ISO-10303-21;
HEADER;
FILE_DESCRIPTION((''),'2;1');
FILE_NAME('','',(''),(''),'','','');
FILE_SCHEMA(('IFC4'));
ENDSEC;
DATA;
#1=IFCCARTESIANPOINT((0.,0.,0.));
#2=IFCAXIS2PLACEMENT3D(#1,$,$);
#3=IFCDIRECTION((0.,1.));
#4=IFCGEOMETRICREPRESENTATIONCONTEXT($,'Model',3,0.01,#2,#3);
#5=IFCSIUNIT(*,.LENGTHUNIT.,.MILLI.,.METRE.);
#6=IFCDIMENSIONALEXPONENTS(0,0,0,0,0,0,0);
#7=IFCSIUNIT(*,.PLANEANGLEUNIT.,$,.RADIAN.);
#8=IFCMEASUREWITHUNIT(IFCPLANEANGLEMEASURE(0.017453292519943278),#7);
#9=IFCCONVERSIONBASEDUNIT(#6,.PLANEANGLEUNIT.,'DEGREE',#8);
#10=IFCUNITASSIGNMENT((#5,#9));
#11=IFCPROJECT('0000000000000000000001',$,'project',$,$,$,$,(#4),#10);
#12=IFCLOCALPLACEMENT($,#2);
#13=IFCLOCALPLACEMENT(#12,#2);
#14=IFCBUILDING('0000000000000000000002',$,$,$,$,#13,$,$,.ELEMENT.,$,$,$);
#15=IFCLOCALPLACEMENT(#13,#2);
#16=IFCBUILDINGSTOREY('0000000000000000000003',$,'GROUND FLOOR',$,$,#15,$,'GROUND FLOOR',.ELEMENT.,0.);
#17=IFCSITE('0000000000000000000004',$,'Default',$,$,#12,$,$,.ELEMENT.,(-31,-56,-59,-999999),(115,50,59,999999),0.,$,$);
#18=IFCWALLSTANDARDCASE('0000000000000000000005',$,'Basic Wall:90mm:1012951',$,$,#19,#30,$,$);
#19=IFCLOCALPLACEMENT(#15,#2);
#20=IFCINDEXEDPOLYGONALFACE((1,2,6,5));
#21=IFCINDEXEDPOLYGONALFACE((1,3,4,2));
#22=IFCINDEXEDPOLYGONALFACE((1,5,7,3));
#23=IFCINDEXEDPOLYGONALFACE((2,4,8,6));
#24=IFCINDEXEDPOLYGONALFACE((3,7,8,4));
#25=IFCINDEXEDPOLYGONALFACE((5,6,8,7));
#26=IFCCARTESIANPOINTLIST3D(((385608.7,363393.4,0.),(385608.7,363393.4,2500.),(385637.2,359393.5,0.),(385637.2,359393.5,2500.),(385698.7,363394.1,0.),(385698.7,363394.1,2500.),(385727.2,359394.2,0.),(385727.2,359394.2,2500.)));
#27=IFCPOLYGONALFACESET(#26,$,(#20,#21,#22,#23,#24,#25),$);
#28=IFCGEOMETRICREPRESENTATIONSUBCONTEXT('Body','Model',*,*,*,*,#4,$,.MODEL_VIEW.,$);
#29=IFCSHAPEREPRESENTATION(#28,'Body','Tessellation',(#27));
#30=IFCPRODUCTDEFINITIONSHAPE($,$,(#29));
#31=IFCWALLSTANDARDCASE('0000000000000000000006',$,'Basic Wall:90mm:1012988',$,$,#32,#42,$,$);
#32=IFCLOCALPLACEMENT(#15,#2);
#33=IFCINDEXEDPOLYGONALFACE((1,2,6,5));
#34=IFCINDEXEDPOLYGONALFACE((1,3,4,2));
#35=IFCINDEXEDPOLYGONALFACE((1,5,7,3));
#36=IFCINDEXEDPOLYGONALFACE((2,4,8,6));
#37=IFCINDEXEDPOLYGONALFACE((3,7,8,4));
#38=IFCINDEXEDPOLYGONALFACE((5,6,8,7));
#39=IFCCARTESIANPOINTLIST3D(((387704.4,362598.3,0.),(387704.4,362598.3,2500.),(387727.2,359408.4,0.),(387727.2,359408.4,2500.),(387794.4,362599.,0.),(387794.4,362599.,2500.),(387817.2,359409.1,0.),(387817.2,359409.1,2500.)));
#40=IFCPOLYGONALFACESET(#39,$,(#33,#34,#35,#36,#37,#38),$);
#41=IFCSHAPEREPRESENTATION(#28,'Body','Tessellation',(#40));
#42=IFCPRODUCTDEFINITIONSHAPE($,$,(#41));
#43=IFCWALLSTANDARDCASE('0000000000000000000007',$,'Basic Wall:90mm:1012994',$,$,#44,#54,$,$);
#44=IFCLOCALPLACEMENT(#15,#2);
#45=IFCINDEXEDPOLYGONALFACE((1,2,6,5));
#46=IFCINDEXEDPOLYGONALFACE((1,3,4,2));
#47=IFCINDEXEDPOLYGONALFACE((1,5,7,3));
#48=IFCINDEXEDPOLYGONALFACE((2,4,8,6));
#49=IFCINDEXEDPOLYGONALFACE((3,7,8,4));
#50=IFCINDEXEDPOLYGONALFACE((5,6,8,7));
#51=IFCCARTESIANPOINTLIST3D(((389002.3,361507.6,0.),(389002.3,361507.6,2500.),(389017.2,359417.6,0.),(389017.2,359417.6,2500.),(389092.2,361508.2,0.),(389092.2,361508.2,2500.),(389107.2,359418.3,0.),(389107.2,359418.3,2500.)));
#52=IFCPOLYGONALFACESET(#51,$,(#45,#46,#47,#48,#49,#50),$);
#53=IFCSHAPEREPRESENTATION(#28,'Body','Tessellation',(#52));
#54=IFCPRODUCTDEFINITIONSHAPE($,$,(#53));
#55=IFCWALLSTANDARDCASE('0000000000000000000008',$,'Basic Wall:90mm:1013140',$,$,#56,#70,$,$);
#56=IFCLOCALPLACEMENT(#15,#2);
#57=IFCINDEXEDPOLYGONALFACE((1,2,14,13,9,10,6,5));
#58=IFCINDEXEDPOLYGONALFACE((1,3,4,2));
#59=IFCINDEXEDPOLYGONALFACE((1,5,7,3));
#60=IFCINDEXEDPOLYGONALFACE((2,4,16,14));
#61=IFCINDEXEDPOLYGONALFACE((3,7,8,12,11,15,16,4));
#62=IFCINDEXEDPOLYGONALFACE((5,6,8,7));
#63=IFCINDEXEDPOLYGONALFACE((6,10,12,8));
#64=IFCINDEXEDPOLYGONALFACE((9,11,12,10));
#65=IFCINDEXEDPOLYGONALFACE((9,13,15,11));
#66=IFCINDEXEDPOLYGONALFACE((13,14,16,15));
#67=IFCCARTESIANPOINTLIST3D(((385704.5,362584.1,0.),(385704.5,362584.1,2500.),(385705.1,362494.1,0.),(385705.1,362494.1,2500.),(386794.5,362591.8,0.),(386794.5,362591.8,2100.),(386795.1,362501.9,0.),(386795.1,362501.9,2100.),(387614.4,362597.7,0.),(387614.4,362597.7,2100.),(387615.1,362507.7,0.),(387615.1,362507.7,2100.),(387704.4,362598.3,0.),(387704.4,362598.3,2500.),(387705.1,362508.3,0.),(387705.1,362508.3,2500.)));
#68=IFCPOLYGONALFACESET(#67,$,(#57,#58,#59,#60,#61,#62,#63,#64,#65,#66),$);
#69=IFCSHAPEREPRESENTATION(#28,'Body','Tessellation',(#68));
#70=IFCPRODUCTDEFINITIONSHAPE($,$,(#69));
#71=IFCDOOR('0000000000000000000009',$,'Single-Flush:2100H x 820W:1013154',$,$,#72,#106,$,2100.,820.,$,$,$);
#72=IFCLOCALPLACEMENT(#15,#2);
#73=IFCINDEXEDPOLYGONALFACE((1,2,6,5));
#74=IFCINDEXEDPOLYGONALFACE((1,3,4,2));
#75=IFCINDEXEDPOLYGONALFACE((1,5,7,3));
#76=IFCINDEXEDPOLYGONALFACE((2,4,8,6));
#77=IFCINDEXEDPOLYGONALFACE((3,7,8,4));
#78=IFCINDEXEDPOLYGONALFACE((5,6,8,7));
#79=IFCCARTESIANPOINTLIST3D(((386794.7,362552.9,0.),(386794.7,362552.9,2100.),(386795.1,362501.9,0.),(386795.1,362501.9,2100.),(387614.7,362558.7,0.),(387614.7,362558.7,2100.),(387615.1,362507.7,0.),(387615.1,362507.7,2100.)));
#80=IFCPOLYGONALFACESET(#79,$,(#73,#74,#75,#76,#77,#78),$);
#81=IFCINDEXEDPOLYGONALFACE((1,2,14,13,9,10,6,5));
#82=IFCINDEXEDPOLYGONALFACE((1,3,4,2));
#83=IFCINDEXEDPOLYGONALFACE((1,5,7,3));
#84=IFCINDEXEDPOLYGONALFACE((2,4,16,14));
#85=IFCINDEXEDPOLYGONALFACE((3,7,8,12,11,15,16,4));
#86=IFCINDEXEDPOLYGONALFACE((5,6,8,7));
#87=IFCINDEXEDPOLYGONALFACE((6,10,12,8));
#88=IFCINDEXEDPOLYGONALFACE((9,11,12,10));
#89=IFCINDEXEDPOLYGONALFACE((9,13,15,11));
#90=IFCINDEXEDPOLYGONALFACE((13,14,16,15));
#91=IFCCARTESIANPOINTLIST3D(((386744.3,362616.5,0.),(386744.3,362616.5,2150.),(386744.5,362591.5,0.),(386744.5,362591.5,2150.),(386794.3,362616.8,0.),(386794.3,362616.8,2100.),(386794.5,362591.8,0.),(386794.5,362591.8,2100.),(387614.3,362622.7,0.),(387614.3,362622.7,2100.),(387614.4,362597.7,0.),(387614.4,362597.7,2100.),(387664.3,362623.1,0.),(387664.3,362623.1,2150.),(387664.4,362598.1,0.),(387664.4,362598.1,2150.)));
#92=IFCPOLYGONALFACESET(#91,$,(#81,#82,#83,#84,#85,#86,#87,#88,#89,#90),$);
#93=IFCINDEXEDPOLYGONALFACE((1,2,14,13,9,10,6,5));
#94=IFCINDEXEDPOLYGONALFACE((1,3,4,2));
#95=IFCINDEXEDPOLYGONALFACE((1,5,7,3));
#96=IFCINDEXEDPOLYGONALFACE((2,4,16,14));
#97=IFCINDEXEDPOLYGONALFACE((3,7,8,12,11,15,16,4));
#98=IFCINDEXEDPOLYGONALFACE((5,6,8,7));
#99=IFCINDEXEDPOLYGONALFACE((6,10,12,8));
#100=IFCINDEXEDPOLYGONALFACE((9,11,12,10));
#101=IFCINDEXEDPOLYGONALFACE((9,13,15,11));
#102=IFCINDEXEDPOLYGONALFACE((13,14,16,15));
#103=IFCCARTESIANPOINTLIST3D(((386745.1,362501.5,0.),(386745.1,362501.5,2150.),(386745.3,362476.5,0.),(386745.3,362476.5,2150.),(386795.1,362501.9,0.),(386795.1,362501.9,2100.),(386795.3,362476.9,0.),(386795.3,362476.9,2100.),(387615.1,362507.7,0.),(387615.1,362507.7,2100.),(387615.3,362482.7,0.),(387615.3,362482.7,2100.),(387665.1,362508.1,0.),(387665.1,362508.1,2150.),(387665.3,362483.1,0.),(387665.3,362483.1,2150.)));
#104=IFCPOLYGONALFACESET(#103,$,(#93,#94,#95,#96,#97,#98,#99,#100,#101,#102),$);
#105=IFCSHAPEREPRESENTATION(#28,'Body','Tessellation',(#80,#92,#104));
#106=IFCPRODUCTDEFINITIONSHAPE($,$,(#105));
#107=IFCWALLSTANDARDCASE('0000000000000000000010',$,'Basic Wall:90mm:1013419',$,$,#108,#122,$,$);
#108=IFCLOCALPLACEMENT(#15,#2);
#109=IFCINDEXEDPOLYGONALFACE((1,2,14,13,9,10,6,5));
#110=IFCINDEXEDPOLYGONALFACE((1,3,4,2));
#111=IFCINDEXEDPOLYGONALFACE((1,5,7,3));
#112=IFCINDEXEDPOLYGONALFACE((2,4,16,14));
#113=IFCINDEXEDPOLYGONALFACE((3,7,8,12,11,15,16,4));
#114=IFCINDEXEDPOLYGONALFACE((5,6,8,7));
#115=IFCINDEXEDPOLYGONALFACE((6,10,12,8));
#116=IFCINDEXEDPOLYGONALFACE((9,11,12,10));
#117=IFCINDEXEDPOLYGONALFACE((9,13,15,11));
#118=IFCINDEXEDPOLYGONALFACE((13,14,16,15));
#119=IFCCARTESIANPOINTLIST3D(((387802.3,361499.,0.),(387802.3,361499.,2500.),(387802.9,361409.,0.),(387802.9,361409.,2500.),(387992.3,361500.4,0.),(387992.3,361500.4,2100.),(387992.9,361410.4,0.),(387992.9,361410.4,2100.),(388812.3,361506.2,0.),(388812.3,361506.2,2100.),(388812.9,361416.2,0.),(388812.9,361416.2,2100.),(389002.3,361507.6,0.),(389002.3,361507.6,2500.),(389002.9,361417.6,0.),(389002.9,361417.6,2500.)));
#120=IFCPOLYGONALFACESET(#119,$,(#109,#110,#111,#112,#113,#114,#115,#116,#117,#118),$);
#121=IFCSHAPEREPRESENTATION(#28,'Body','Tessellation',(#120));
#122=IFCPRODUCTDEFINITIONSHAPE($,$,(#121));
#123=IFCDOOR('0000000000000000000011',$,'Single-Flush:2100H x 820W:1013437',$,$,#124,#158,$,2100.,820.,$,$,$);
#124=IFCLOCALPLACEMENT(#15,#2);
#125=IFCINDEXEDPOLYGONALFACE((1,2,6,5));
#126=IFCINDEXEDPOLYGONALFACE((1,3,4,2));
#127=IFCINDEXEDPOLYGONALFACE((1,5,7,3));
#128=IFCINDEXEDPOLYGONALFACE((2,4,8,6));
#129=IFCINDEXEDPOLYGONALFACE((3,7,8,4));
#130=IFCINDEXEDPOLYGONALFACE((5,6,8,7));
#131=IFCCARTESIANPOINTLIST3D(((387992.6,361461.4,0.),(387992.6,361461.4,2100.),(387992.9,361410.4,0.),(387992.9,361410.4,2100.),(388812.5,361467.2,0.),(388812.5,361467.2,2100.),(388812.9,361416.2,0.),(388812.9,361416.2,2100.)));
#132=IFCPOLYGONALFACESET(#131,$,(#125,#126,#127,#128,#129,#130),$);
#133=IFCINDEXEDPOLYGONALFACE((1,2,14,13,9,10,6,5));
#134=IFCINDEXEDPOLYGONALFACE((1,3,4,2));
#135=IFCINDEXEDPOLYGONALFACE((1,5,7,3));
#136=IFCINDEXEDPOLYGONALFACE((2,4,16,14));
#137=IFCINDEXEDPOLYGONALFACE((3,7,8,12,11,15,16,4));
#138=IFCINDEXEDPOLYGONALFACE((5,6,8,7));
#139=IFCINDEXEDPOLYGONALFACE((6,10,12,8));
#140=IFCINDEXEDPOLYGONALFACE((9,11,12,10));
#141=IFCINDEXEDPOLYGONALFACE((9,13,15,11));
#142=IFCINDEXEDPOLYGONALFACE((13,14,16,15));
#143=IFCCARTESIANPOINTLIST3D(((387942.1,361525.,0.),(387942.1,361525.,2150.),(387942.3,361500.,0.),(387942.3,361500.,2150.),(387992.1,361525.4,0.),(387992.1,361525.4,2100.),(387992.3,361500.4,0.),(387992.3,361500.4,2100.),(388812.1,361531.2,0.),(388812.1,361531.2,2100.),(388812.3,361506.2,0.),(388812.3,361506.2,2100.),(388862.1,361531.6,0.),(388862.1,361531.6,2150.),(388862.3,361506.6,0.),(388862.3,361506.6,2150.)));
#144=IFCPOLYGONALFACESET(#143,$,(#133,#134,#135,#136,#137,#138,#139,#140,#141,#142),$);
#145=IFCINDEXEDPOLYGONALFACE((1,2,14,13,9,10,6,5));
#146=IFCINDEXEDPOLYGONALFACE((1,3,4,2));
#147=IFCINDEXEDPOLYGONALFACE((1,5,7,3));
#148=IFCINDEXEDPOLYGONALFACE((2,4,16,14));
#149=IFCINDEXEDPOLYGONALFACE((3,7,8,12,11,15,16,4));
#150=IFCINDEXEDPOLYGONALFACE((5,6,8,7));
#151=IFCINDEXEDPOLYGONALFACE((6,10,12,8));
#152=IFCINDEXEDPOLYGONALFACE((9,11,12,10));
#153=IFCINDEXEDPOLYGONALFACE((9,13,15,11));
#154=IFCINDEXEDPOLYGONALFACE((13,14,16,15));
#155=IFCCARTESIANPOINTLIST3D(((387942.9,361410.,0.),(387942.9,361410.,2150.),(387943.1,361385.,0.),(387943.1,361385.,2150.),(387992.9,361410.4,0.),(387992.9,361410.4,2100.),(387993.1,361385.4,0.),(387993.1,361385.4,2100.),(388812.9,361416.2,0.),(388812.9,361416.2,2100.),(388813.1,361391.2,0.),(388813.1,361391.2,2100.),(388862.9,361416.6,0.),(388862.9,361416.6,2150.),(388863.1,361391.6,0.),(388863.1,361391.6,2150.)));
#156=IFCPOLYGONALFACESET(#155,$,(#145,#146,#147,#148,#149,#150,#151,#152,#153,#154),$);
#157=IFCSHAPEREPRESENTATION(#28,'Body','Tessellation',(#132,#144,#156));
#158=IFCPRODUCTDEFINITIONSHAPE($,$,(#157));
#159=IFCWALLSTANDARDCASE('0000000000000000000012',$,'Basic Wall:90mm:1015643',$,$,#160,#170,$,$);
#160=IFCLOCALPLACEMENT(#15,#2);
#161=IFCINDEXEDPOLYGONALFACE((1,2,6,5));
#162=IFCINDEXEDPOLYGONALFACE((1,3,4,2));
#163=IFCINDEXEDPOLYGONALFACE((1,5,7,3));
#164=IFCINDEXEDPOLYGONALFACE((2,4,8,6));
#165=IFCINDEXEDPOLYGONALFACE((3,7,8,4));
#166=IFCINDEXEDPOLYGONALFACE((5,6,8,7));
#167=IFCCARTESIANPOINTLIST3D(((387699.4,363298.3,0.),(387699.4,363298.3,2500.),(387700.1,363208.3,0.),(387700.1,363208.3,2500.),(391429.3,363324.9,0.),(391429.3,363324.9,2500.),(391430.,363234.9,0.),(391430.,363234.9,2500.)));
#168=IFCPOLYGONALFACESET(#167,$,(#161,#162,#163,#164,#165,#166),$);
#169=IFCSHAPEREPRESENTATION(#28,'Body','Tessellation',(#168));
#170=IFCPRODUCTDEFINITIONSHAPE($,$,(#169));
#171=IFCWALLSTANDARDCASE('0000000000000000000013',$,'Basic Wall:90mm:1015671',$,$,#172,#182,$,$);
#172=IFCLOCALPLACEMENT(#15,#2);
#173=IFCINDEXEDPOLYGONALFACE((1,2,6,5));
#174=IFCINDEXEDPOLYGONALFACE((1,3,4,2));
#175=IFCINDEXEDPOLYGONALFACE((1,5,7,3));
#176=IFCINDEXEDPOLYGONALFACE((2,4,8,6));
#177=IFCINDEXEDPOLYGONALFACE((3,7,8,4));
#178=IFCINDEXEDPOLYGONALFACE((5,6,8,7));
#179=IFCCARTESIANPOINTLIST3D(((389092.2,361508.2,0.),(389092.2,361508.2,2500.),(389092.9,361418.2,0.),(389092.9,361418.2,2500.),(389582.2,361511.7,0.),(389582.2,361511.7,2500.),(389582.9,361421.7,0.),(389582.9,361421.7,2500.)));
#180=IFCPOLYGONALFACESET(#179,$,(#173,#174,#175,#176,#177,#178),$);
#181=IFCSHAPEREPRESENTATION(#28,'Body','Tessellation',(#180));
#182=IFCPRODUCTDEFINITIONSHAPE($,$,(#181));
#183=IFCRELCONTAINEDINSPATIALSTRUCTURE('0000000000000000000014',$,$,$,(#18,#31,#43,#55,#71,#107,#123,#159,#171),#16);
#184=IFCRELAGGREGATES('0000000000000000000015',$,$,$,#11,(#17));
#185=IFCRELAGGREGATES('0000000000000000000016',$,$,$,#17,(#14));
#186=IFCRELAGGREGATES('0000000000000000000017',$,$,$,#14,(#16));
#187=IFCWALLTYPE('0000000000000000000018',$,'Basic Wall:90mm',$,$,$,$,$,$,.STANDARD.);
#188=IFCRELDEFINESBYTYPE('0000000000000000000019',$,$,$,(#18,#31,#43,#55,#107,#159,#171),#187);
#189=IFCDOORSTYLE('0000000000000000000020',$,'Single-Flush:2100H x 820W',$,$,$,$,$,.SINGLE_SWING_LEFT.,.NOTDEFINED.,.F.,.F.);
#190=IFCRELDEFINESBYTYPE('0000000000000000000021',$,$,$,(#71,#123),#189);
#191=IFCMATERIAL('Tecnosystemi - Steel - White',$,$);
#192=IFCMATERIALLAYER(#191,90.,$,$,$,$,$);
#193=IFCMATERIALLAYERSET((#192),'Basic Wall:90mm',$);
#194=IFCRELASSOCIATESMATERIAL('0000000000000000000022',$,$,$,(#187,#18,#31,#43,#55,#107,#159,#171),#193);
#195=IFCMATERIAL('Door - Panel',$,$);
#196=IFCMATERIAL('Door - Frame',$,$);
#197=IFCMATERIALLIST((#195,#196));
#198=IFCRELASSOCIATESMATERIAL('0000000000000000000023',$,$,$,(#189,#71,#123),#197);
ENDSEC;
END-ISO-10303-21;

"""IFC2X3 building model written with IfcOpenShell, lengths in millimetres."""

from ifc_helpers import new_model, entity, si_unit, converted_unit, direction, frame, frame_2d, origin, origin_2d_with_axis, place, context, subcontext, project, spatial, polyline, rectangle, outline, extrude, source, transform, mapped, material, material_list, layer, layer_set, layer_usage, type_object, type_shapes, element, fill, save


model = new_model("IFC2X3")

# Units and contexts
model_context = context("Model", 3, precision=0.01, world=origin(), true_north=direction((0.0, 1.0)))
body_context = subcontext(model_context, "Body", "Model", "MODEL_VIEW")
ifc_project = project(units=[si_unit("LENGTHUNIT", "METRE", prefix="MILLI"), converted_unit("PLANEANGLEUNIT", "DEGREE", entity("IfcPlaneAngleMeasure", 0.017453292519943278), si_unit("PLANEANGLEUNIT", "RADIAN"), dimensions=[0, 0, 0, 0, 0, 0, 0])], contexts=[model_context])

# Site, building, storey
site_placement = place(None, origin())
site = spatial("IfcSite", under=ifc_project, at=site_placement, Name="Default", CompositionType="ELEMENT", RefLatitude=(-31, -56, -59, -999999), RefLongitude=(115, 50, 59, 999999), RefElevation=0.0)
building_placement = place(site_placement, origin())
building = spatial("IfcBuilding", under=site, at=building_placement, CompositionType="ELEMENT")
storey_placement = place(building_placement, origin())
storey = spatial("IfcBuildingStorey", under=building, at=storey_placement, Name="GROUND FLOOR", LongName="GROUND FLOOR", CompositionType="ELEMENT", Elevation=0.0)

# Walls
ifc_material_1 = material(Name="Tecnosystemi - Steel - White")
ifc_layer_1 = layer(ifc_material_1, 90.0)
ifc_layer_set_1 = layer_set([ifc_layer_1], Name="Basic Wall:90mm")
ifc_layer_usage_1 = layer_usage(ifc_layer_set_1, "AXIS2", "NEGATIVE", 45.0)
wall_type_1 = type_object("IfcWallType", Name="Basic Wall:90mm", PredefinedType="STANDARD", material=ifc_layer_set_1)
wall_1_placement = place(storey_placement, frame((385653.7, 363393.7, 0.0), z_axis=(0.0, 0.0, 1.0), x_axis=(0.007134, -0.999975, 0.0)))
element("IfcWallStandardCase", 1, at=wall_1_placement, inside=storey, type_object=wall_type_1, material=ifc_layer_usage_1, Name="Basic Wall:90mm:1012951", context=body_context, shape_type="SweptSolid", body=[
    extrude(rectangle(XDim=4000.0, YDim=90.0, at=frame_2d((2000.0, 0.0), x_axis=(-1.0, 0.0))), origin(), (0.0, 0.0, 1.0), 2500.0),
])
ifc_layer_usage_2 = layer_usage(ifc_layer_set_1, "AXIS2", "NEGATIVE", 45.0)
wall_2_placement = place(storey_placement, frame((387749.4, 362598.7, 0.0), z_axis=(0.0, 0.0, 1.0), x_axis=(0.007134, -0.999975, 0.0)))
element("IfcWallStandardCase", 2, at=wall_2_placement, inside=storey, type_object=wall_type_1, material=ifc_layer_usage_2, Name="Basic Wall:90mm:1012988", context=body_context, shape_type="SweptSolid", body=[
    extrude(rectangle(XDim=3190.0, YDim=90.0, at=frame_2d((1595.0, 0.0), x_axis=(-1.0, 0.0))), origin(), (0.0, 0.0, 1.0), 2500.0),
])
ifc_layer_usage_3 = layer_usage(ifc_layer_set_1, "AXIS2", "NEGATIVE", 45.0)
wall_3_placement = place(storey_placement, frame((389047.3, 361507.9, 0.0), z_axis=(0.0, 0.0, 1.0), x_axis=(0.007134, -0.999975, 0.0)))
element("IfcWallStandardCase", 3, at=wall_3_placement, inside=storey, type_object=wall_type_1, material=ifc_layer_usage_3, Name="Basic Wall:90mm:1012994", context=body_context, shape_type="SweptSolid", body=[
    extrude(rectangle(XDim=2090.0, YDim=90.0, at=frame_2d((1045.0, 0.0), x_axis=(-1.0, 0.0))), origin(), (0.0, 0.0, 1.0), 2500.0),
])

# Walls, openings, doors
ifc_layer_usage_4 = layer_usage(ifc_layer_set_1, "AXIS2", "NEGATIVE", 45.0)
wall_4_placement = place(storey_placement, frame((385704.8, 362539.1, 0.0), z_axis=(0.0, 0.0, 1.0), x_axis=(0.999975, 0.007134, 0.0)))
wall_4 = element("IfcWallStandardCase", 4, at=wall_4_placement, inside=storey, type_object=wall_type_1, material=ifc_layer_usage_4, Name="Basic Wall:90mm:1013140", context=body_context, shape_type="SweptSolid", body=[
    extrude(rectangle(XDim=2000.0, YDim=90.0, at=frame_2d((1000.0, 0.0), x_axis=(1.0, 0.0))), origin(), (0.0, 0.0, 1.0), 2500.0),
])
opening_1_placement = place(wall_4_placement, frame((1910.0, 45.0, 0.0)))
opening_1 = element("IfcOpeningElement", 5, at=opening_1_placement, cuts=wall_4, ObjectType="Opening", context=body_context, shape_type="SweptSolid", body=[
    extrude(rectangle(XDim=820.0, YDim=2100.0, at=frame_2d((1050.0, 410.0), x_axis=(0.0, -1.0))), frame((0.0, 0.0, 0.0), z_axis=(0.0, -1.0, 0.0), x_axis=(0.0, 0.0, 1.0)), (0.0, 0.0, 1.0), 90.0),
])
ifc_material_2 = material(Name="Door - Panel")
ifc_material_3 = material(Name="Door - Frame")
ifc_material_list_1 = material_list([ifc_material_2, ifc_material_3])
door_style_1 = type_object("IfcDoorStyle", Name="Single-Flush:2100H x 820W", ConstructionType="NOTDEFINED", OperationType="SINGLE_SWING_LEFT", ParameterTakesPrecedence=False, Sizeable=False, material=ifc_material_list_1)
shared_shape_1 = source(origin(), body_context, "Body", "SweptSolid", [
    extrude(rectangle(XDim=820.0, YDim=51.0, at=origin_2d_with_axis()), frame((410.0, 64.5, 0.0)), (0.0, 0.0, 1.0), 2100.0),
    extrude(outline(polyline([(-1087.5, -460.0), (1062.5, -460.0), (1062.5, -410.0), (-1037.5, -410.0), (-1037.5, 410.0), (1062.5, 410.0), (1062.5, 460.0), (-1087.5, 460.0), (-1087.5, -460.0)])), frame((410.0, 0.0, 1062.5), z_axis=(0.0, -1.0, 0.0), x_axis=(0.0, 0.0, -1.0)), (0.0, 0.0, 1.0), 25.0),
    extrude(outline(polyline([(-460.0, -1087.5), (460.0, -1087.5), (460.0, 1062.5), (410.0, 1062.5), (410.0, -1037.5), (-410.0, -1037.5), (-410.0, 1062.5), (-460.0, 1062.5), (-460.0, -1087.5)])), frame((410.0, 115.0, 1062.5), z_axis=(0.0, -1.0, 0.0), x_axis=(-1.0, 0.0, 0.0)), (0.0, 0.0, 1.0), 25.0),
])
type_shapes(door_style_1, [shared_shape_1])
door_1_placement = place(opening_1_placement, frame((0.0, 0.0, 0.0), z_axis=(0.0, 0.0, 1.0), x_axis=(-1.0, 0.0, 0.0)))
door_1 = element("IfcDoor", 6, at=door_1_placement, inside=storey, type_object=door_style_1, material=ifc_material_list_1, Name="Single-Flush:2100H x 820W:1013154", OverallHeight=2100.0, OverallWidth=820.0, context=body_context, shape_type="MappedRepresentation", body=[
    mapped(shared_shape_1, transform((0.0, 0.0, 0.0), scale=1.0)),
])
fill(opening_1, door_1)
ifc_layer_usage_5 = layer_usage(ifc_layer_set_1, "AXIS2", "NEGATIVE", 45.0)
wall_5_placement = place(storey_placement, frame((387802.6, 361454.0, 0.0), z_axis=(0.0, 0.0, 1.0), x_axis=(0.999975, 0.007134, 0.0)))
wall_5 = element("IfcWallStandardCase", 7, at=wall_5_placement, inside=storey, type_object=wall_type_1, material=ifc_layer_usage_5, Name="Basic Wall:90mm:1013419", context=body_context, shape_type="SweptSolid", body=[
    extrude(rectangle(XDim=1200.0, YDim=90.0, at=frame_2d((600.0, 0.0), x_axis=(1.0, 0.0))), origin(), (0.0, 0.0, 1.0), 2500.0),
])
opening_2_placement = place(wall_5_placement, frame((1010.0, 45.0, 0.0)))
opening_2 = element("IfcOpeningElement", 8, at=opening_2_placement, cuts=wall_5, ObjectType="Opening", context=body_context, shape_type="SweptSolid", body=[
    extrude(rectangle(XDim=820.0, YDim=2100.0, at=frame_2d((1050.0, 410.0), x_axis=(0.0, -1.0))), frame((0.0, 0.0, 0.0), z_axis=(0.0, -1.0, 0.0), x_axis=(0.0, 0.0, 1.0)), (0.0, 0.0, 1.0), 90.0),
])
door_2_placement = place(opening_2_placement, frame((0.0, 0.0, 0.0), z_axis=(0.0, 0.0, 1.0), x_axis=(-1.0, 0.0, 0.0)))
door_2 = element("IfcDoor", 9, at=door_2_placement, inside=storey, type_object=door_style_1, material=ifc_material_list_1, Name="Single-Flush:2100H x 820W:1013437", OverallHeight=2100.0, OverallWidth=820.0, context=body_context, shape_type="MappedRepresentation", body=[
    mapped(shared_shape_1, transform((0.0, 0.0, 0.0), scale=1.0)),
])
fill(opening_2, door_2)

# Walls
ifc_layer_usage_6 = layer_usage(ifc_layer_set_1, "AXIS2", "NEGATIVE", 45.0)
wall_6_placement = place(storey_placement, frame((387699.8, 363253.3, 0.0), z_axis=(0.0, 0.0, 1.0), x_axis=(0.999975, 0.007134, 0.0)))
element("IfcWallStandardCase", 10, at=wall_6_placement, inside=storey, type_object=wall_type_1, material=ifc_layer_usage_6, Name="Basic Wall:90mm:1015643", context=body_context, shape_type="SweptSolid", body=[
    extrude(rectangle(XDim=3730.0, YDim=90.0, at=frame_2d((1865.0, 0.0), x_axis=(-1.0, 0.0))), origin(), (0.0, 0.0, 1.0), 2500.0),
])
ifc_layer_usage_7 = layer_usage(ifc_layer_set_1, "AXIS2", "NEGATIVE", 45.0)
wall_7_placement = place(storey_placement, frame((389092.6, 361463.2, 0.0), z_axis=(0.0, 0.0, 1.0), x_axis=(0.999975, 0.007134, 0.0)))
element("IfcWallStandardCase", 11, at=wall_7_placement, inside=storey, type_object=wall_type_1, material=ifc_layer_usage_7, Name="Basic Wall:90mm:1015671", context=body_context, shape_type="SweptSolid", body=[
    extrude(rectangle(XDim=490.0, YDim=90.0, at=frame_2d((245.0, 0.0), x_axis=(-1.0, 0.0))), origin(), (0.0, 0.0, 1.0), 2500.0),
])

save(model, "model.ifc")
